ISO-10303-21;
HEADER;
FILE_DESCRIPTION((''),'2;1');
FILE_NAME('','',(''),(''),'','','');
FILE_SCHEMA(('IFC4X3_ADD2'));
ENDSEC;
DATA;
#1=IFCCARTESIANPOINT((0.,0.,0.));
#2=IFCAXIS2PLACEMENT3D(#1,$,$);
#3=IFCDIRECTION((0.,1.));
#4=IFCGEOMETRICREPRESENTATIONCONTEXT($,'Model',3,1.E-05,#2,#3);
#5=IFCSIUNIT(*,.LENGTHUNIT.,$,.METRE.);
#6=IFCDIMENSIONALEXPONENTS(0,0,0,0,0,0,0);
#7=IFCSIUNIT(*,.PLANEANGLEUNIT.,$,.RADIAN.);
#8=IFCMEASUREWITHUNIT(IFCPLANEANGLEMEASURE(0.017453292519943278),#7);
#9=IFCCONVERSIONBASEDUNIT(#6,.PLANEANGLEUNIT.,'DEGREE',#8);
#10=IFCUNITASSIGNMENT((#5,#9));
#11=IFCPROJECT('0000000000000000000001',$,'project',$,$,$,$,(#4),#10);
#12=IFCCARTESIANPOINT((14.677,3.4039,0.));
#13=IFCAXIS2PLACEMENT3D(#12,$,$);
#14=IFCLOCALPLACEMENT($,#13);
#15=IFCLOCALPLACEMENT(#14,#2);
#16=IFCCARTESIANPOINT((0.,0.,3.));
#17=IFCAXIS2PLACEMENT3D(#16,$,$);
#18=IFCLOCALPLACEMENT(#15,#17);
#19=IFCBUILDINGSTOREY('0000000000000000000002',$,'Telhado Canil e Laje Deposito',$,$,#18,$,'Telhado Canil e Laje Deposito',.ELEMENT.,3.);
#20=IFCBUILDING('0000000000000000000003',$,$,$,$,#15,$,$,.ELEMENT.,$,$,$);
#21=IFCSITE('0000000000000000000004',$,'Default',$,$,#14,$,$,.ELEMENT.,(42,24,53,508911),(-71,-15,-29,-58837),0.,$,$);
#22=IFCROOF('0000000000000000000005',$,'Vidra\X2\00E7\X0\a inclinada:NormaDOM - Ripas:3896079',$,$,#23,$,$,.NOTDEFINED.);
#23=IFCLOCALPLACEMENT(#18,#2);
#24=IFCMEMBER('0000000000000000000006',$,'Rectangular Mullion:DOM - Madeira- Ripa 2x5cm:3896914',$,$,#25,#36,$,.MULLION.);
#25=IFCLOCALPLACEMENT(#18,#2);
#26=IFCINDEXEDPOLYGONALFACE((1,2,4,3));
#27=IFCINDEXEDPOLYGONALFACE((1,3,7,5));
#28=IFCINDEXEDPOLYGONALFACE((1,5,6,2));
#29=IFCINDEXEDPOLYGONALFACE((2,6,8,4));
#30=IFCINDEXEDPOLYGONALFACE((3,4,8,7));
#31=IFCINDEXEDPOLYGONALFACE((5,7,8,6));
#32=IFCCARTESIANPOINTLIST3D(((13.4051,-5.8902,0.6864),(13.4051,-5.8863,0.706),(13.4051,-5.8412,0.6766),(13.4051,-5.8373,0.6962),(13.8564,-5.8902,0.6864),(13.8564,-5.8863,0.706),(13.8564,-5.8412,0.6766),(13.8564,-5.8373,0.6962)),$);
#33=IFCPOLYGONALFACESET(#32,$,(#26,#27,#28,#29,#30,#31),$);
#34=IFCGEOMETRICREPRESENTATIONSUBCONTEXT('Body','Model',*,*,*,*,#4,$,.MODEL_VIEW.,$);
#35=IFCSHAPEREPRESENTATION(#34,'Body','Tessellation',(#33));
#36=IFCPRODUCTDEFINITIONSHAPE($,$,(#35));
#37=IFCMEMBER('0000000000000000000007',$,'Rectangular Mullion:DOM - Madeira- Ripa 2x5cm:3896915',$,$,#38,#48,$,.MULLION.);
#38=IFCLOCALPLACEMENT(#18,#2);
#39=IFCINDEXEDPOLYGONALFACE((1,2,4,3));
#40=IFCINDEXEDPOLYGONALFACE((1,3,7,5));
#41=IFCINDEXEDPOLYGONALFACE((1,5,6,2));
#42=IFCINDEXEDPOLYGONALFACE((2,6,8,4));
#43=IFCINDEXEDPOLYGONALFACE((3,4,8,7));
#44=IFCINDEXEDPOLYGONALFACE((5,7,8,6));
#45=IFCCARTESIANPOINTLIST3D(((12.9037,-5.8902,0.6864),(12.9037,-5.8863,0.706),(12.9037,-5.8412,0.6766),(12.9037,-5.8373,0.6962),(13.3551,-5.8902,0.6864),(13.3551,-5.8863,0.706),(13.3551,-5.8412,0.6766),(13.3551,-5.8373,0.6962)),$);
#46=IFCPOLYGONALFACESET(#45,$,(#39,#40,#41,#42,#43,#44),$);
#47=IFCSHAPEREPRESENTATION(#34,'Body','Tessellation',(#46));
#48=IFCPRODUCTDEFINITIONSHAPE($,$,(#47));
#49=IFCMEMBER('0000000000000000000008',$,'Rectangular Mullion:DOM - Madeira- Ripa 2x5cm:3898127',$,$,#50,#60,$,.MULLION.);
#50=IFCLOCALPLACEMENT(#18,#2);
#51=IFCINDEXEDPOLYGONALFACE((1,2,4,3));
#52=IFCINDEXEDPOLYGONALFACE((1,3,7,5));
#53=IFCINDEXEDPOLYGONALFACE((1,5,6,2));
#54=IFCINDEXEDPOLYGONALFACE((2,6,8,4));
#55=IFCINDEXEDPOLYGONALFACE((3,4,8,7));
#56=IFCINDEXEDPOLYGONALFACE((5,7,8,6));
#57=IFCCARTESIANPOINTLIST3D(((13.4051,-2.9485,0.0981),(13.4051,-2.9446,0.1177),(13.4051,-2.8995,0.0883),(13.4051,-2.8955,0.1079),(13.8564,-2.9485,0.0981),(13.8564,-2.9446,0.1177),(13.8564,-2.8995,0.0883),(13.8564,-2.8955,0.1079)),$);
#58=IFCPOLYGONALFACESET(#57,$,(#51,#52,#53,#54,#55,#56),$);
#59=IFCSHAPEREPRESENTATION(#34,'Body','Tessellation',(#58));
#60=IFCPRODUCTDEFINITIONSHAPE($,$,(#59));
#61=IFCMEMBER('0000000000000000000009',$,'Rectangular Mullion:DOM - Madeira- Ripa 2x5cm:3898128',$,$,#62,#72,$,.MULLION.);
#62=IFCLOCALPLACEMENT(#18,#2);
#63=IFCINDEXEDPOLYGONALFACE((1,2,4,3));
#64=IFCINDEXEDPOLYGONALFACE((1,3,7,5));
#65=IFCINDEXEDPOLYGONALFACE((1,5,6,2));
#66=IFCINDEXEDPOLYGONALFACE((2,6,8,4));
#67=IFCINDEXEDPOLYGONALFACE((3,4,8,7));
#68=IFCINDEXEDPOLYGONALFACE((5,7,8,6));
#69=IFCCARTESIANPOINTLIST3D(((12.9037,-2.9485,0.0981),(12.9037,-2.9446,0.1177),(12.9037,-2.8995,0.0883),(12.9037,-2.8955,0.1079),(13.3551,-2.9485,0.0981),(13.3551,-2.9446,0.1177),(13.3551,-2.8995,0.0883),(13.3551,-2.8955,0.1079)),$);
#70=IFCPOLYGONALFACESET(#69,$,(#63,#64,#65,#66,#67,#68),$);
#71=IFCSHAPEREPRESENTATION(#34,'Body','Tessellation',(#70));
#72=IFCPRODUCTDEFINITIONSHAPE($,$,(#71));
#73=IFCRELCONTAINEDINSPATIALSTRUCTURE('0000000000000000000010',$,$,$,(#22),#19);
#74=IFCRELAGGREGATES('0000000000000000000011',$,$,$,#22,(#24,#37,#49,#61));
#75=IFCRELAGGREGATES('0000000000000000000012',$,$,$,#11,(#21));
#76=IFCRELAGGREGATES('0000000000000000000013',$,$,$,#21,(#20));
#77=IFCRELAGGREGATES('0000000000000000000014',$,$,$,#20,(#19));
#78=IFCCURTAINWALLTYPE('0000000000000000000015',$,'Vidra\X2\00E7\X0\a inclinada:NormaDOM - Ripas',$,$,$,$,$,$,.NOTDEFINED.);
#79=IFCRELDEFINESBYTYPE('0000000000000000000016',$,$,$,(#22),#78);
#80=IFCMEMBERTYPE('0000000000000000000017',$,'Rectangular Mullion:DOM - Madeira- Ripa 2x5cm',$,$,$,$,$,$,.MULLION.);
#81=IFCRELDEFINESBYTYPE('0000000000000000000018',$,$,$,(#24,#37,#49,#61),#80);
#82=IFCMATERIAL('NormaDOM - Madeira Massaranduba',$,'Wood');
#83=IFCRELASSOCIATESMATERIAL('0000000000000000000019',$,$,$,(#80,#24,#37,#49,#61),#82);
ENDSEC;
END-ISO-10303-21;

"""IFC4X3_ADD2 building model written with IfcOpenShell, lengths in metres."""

from ifc_helpers import new_model, entity, si_unit, converted_unit, direction, frame, origin, origin_2d_with_axis, place, context, subcontext, project, spatial, rectangle, extrude, source, transform, mapped, material, material_profile, profile_set, profile_usage, type_object, type_shapes, element, aggregate, save


model = new_model("IFC4X3_ADD2")

# Units and contexts
model_context = context("Model", 3, precision=1e-05, world=origin(), true_north=direction((0.0, 1.0)))
body_context = subcontext(model_context, "Body", "Model", "MODEL_VIEW")
ifc_project = project(units=[si_unit("LENGTHUNIT", "METRE"), converted_unit("PLANEANGLEUNIT", "DEGREE", entity("IfcPlaneAngleMeasure", 0.017453292519943278), si_unit("PLANEANGLEUNIT", "RADIAN"), dimensions=[0, 0, 0, 0, 0, 0, 0])], contexts=[model_context])

# Site, building, storey
site_placement = place(None, frame((14.677, 3.4039, 0.0)))
site = spatial("IfcSite", under=ifc_project, at=site_placement, Name="Default", CompositionType="ELEMENT", RefLatitude=(42, 24, 53, 508911), RefLongitude=(-71, -15, -29, -58837), RefElevation=0.0)
building_placement = place(site_placement, origin())
building = spatial("IfcBuilding", under=site, at=building_placement, CompositionType="ELEMENT")
storey_placement = place(building_placement, frame((0.0, 0.0, 3.0)))
storey = spatial("IfcBuildingStorey", under=building, at=storey_placement, Name="Telhado Canil e Laje Deposito", LongName="Telhado Canil e Laje Deposito", CompositionType="ELEMENT", Elevation=3.0)

# Roof
ifc_material = material(Name="NormaDOM - Madeira Massaranduba", Category="Wood")
ifc_material_profile_1 = material_profile(ifc_material, rectangle(XDim=0.05, YDim=0.02, at=origin_2d_with_axis()), Name="DOM - Madeira- Ripa 2x5cm")
ifc_profile_set_1 = profile_set([ifc_material_profile_1], Name="DOM - Madeira- Ripa 2x5cm")
ifc_profile_usage_1 = profile_usage(ifc_profile_set_1)
curtain_wall_type_1 = type_object("IfcCurtainWallType", Name="Vidraça inclinada:NormaDOM - Ripas", PredefinedType="NOTDEFINED")
roof_1_placement = place(storey_placement, frame((0.0, 0.0, -3.0)))
roof_1 = element("IfcRoof", 1, at=roof_1_placement, inside=storey, type_object=curtain_wall_type_1, Name="Vidraça inclinada:NormaDOM - Ripas:3896079", PredefinedType="NOTDEFINED")

# Members
member_type_1 = type_object("IfcMemberType", Name="Rectangular Mullion:DOM - Madeira- Ripa 2x5cm", PredefinedType="MULLION", material=ifc_profile_set_1)
shared_shape_1 = source(origin(), body_context, "Body", "SweptSolid", [
    extrude(rectangle(XDim=0.05, YDim=0.02, at=origin_2d_with_axis()), frame((0.025, 0.01, -0.4514), z_axis=(0.0, 0.0, 1.0), x_axis=(-1.0, 0.0, 0.0)), (0.0, 0.0, 1.0), 0.4514),
])
type_shapes(member_type_1, [shared_shape_1])
member_1_placement = place(roof_1_placement, frame((13.8564, -5.8373, 3.6962), z_axis=(1.0, 0.0, 0.0), x_axis=(0.0, -0.980581, 0.196116)))
member_1 = element("IfcMember", 2, at=member_1_placement, type_object=member_type_1, material=ifc_profile_usage_1, Name="Rectangular Mullion:DOM - Madeira- Ripa 2x5cm:3896914", PredefinedType="MULLION", context=body_context, shape_type="MappedRepresentation", body=[
    mapped(shared_shape_1, transform((0.0, 0.0, 0.0), scale=1.0)),
])
member_2_placement = place(roof_1_placement, frame((13.3551, -5.8373, 3.6962), z_axis=(1.0, 0.0, 0.0), x_axis=(0.0, -0.980581, 0.196116)))
member_2 = element("IfcMember", 3, at=member_2_placement, type_object=member_type_1, material=ifc_profile_usage_1, Name="Rectangular Mullion:DOM - Madeira- Ripa 2x5cm:3896915", PredefinedType="MULLION", context=body_context, shape_type="MappedRepresentation", body=[
    mapped(shared_shape_1, transform((0.0, 0.0, 0.0), scale=1.0)),
])
member_3_placement = place(roof_1_placement, frame((13.8564, -2.8955, 3.1079), z_axis=(1.0, 0.0, 0.0), x_axis=(0.0, -0.980581, 0.196116)))
member_3 = element("IfcMember", 4, at=member_3_placement, type_object=member_type_1, material=ifc_profile_usage_1, Name="Rectangular Mullion:DOM - Madeira- Ripa 2x5cm:3898127", PredefinedType="MULLION", context=body_context, shape_type="MappedRepresentation", body=[
    mapped(shared_shape_1, transform((0.0, 0.0, 0.0), scale=1.0)),
])
member_4_placement = place(roof_1_placement, frame((13.3551, -2.8955, 3.1079), z_axis=(1.0, 0.0, 0.0), x_axis=(0.0, -0.980581, 0.196116)))
member_4 = element("IfcMember", 5, at=member_4_placement, type_object=member_type_1, material=ifc_profile_usage_1, Name="Rectangular Mullion:DOM - Madeira- Ripa 2x5cm:3898128", PredefinedType="MULLION", context=body_context, shape_type="MappedRepresentation", body=[
    mapped(shared_shape_1, transform((0.0, 0.0, 0.0), scale=1.0)),
])
aggregate(roof_1, [member_1, member_2, member_3, member_4])

save(model, "model.ifc")
